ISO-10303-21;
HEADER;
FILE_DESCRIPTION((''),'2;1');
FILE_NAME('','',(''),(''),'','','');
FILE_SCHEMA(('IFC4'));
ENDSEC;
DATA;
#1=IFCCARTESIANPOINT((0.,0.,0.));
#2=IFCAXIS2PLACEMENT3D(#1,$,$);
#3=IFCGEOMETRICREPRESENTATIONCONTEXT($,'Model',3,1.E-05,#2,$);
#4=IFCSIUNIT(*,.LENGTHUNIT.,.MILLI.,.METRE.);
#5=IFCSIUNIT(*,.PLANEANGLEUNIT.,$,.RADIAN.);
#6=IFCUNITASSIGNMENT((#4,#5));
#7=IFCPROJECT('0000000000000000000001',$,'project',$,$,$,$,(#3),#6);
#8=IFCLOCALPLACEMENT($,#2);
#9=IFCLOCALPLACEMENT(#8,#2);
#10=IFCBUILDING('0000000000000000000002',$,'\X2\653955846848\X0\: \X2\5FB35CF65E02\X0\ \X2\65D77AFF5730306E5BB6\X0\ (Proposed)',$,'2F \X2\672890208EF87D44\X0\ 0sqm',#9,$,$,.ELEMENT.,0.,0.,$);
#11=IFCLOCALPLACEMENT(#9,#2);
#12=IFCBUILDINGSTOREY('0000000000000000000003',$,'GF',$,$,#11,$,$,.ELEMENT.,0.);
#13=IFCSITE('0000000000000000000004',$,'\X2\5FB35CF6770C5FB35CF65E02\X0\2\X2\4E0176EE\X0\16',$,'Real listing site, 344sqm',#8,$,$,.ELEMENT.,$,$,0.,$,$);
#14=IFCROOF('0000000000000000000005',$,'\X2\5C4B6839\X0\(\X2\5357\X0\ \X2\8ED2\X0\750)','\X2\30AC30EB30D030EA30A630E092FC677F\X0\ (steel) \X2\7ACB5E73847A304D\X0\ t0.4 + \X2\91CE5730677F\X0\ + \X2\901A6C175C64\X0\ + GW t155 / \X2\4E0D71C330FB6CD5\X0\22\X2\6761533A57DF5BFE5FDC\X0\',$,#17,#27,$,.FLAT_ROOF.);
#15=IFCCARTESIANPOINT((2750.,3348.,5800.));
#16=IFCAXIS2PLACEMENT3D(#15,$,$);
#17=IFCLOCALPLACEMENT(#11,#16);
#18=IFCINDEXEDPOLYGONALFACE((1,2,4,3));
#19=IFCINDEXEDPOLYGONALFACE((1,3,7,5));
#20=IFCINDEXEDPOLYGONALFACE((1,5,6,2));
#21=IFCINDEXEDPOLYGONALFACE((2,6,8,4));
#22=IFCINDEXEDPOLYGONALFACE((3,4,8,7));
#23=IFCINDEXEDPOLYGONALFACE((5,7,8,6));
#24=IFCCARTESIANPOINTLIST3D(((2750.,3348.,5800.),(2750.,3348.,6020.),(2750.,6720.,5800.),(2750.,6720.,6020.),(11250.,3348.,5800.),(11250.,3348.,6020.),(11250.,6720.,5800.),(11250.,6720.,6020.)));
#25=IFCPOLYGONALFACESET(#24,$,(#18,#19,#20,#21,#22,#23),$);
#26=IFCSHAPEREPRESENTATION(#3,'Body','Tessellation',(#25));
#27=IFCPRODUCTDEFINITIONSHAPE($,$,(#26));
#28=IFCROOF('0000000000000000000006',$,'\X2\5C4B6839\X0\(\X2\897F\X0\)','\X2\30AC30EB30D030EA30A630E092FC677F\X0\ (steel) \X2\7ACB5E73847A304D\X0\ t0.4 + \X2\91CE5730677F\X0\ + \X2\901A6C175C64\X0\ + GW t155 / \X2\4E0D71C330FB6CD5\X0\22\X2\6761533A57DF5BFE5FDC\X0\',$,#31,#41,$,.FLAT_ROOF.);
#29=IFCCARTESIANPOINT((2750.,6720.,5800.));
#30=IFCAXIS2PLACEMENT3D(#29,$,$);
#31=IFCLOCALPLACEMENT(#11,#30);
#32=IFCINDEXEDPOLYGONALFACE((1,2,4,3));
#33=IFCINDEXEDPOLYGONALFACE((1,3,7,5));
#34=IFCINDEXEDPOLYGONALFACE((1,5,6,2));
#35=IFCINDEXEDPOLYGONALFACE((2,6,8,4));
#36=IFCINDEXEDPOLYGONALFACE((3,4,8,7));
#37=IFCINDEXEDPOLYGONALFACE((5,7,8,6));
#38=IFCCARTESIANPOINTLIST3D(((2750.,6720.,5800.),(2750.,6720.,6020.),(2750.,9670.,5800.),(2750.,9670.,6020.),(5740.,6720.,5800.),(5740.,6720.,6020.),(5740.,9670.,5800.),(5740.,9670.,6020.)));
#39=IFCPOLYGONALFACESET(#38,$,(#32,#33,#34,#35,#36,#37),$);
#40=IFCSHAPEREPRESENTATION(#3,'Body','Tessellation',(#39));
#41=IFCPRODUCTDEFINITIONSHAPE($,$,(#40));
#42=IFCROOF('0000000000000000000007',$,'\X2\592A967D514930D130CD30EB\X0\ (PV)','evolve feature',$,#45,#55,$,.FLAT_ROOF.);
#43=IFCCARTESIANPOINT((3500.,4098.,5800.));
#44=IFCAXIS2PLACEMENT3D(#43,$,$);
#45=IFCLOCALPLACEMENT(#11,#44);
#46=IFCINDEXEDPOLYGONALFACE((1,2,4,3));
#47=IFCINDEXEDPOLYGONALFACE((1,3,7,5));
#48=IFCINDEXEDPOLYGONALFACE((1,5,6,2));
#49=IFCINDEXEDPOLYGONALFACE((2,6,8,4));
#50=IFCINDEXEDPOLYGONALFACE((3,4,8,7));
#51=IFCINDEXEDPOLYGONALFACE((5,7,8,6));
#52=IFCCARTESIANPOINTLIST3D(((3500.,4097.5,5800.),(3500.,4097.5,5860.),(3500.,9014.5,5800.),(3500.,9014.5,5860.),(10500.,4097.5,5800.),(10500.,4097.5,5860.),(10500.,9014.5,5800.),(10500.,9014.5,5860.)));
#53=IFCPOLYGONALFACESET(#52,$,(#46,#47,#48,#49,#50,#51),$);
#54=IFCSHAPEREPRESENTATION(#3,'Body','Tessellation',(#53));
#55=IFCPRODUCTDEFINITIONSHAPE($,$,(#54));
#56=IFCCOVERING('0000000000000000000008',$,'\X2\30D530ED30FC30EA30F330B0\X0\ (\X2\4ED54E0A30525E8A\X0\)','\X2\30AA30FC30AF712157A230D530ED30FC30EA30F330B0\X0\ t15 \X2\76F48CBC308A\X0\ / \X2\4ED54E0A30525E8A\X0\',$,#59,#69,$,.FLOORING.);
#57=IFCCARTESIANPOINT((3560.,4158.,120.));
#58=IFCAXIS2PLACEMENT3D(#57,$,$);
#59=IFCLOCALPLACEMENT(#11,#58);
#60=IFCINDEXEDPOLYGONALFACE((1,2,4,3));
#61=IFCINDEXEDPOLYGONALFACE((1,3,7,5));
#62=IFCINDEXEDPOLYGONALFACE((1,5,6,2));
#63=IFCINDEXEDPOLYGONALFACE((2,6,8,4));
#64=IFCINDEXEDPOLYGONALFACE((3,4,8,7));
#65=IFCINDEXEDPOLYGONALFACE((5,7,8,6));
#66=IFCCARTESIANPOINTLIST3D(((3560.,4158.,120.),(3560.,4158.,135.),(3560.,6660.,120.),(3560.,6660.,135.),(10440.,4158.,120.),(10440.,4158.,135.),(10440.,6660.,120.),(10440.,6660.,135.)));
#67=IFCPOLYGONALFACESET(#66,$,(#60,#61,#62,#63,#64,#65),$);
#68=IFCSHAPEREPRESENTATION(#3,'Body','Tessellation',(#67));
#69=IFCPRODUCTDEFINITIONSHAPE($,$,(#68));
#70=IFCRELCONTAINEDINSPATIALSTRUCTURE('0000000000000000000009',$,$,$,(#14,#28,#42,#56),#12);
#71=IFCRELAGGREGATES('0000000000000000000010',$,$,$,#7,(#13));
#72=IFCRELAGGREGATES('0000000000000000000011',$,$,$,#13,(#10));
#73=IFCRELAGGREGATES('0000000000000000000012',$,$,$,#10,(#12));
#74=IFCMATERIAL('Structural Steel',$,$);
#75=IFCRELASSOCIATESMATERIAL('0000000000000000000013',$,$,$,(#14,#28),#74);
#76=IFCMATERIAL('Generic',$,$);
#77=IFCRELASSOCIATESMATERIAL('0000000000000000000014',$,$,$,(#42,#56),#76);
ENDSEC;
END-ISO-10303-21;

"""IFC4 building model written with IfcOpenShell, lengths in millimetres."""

from ifc_helpers import new_model, si_unit, frame, frame_2d, origin, place, context, project, spatial, rectangle, extrude, material, element, save


model = new_model("IFC4")

# Units and contexts
model_context = context("Model", 3, precision=1e-05, world=origin())
ifc_project = project(units=[si_unit("LENGTHUNIT", "METRE", prefix="MILLI"), si_unit("PLANEANGLEUNIT", "RADIAN")], contexts=[model_context])

# Site, building, storey
site_placement = place(None, origin())
site = spatial("IfcSite", under=ifc_project, at=site_placement, Name="徳島県徳島市2丁目16", ObjectType="Real listing site, 344sqm", CompositionType="ELEMENT", RefElevation=0.0)
building_placement = place(site_placement, origin())
building = spatial("IfcBuilding", under=site, at=building_placement, Name="改善案: 徳島市 旗竿地の家 (Proposed)", ObjectType="2F 木造軸組 0sqm", CompositionType="ELEMENT", ElevationOfRefHeight=0.0, ElevationOfTerrain=0.0)
storey_placement = place(building_placement, origin())
storey = spatial("IfcBuildingStorey", under=building, at=storey_placement, Name="GF", CompositionType="ELEMENT", Elevation=0.0)

# Shared definitions
ifc_material_1 = material(Name="Generic")

# Roofs
ifc_material_2 = material(Name="Structural Steel")
roof_1_placement = place(storey_placement, frame((2750.0, 3348.0, 5800.0)))
element("IfcRoof", 1, at=roof_1_placement, inside=storey, material=ifc_material_2, Name="屋根(南 軒750)", Description="ガルバリウム鋼板 (steel) 立平葺き t0.4 + 野地板 + 通気層 + GW t155 / 不燃・法22条区域対応", PredefinedType="FLAT_ROOF", context=model_context, shape_type="SweptSolid", body=[
    extrude(rectangle(XDim=8500.0, YDim=3372.0, at=frame_2d((4250.0, 1686.0))), frame((2750.0, 3348.0, 5800.0)), (0.0, 0.0, 1.0), 220.0),
])
roof_2_placement = place(storey_placement, frame((2750.0, 6720.0, 5800.0)))
element("IfcRoof", 2, at=roof_2_placement, inside=storey, material=ifc_material_2, Name="屋根(西)", Description="ガルバリウム鋼板 (steel) 立平葺き t0.4 + 野地板 + 通気層 + GW t155 / 不燃・法22条区域対応", PredefinedType="FLAT_ROOF", context=model_context, shape_type="SweptSolid", body=[
    extrude(rectangle(XDim=2990.0, YDim=2950.0, at=frame_2d((1495.0, 1475.0))), frame((2750.0, 6720.0, 5800.0)), (0.0, 0.0, 1.0), 220.0),
])
roof_3_placement = place(storey_placement, frame((3500.0, 4098.0, 5800.0)))
element("IfcRoof", 3, at=roof_3_placement, inside=storey, material=ifc_material_1, Name="太陽光パネル (PV)", Description="evolve feature", PredefinedType="FLAT_ROOF", context=model_context, shape_type="SweptSolid", body=[
    extrude(rectangle(XDim=7000.0, YDim=4917.0, at=frame_2d((3500.0, 2458.0))), frame((3500.0, 4098.0, 5800.0)), (0.0, 0.0, 1.0), 60.0),
])

# Covering
covering_placement = place(storey_placement, frame((3560.0, 4158.0, 120.0)))
element("IfcCovering", 4, at=covering_placement, inside=storey, material=ifc_material_1, Name="フローリング (仕上げ床)", Description="オーク無垢フローリング t15 直貼り / 仕上げ床", PredefinedType="FLOORING", context=model_context, shape_type="SweptSolid", body=[
    extrude(rectangle(XDim=6880.0, YDim=2502.0, at=frame_2d((3440.0, 1251.0))), frame((3560.0, 4158.0, 120.0)), (0.0, 0.0, 1.0), 15.0),
])

save(model, "model.ifc")
